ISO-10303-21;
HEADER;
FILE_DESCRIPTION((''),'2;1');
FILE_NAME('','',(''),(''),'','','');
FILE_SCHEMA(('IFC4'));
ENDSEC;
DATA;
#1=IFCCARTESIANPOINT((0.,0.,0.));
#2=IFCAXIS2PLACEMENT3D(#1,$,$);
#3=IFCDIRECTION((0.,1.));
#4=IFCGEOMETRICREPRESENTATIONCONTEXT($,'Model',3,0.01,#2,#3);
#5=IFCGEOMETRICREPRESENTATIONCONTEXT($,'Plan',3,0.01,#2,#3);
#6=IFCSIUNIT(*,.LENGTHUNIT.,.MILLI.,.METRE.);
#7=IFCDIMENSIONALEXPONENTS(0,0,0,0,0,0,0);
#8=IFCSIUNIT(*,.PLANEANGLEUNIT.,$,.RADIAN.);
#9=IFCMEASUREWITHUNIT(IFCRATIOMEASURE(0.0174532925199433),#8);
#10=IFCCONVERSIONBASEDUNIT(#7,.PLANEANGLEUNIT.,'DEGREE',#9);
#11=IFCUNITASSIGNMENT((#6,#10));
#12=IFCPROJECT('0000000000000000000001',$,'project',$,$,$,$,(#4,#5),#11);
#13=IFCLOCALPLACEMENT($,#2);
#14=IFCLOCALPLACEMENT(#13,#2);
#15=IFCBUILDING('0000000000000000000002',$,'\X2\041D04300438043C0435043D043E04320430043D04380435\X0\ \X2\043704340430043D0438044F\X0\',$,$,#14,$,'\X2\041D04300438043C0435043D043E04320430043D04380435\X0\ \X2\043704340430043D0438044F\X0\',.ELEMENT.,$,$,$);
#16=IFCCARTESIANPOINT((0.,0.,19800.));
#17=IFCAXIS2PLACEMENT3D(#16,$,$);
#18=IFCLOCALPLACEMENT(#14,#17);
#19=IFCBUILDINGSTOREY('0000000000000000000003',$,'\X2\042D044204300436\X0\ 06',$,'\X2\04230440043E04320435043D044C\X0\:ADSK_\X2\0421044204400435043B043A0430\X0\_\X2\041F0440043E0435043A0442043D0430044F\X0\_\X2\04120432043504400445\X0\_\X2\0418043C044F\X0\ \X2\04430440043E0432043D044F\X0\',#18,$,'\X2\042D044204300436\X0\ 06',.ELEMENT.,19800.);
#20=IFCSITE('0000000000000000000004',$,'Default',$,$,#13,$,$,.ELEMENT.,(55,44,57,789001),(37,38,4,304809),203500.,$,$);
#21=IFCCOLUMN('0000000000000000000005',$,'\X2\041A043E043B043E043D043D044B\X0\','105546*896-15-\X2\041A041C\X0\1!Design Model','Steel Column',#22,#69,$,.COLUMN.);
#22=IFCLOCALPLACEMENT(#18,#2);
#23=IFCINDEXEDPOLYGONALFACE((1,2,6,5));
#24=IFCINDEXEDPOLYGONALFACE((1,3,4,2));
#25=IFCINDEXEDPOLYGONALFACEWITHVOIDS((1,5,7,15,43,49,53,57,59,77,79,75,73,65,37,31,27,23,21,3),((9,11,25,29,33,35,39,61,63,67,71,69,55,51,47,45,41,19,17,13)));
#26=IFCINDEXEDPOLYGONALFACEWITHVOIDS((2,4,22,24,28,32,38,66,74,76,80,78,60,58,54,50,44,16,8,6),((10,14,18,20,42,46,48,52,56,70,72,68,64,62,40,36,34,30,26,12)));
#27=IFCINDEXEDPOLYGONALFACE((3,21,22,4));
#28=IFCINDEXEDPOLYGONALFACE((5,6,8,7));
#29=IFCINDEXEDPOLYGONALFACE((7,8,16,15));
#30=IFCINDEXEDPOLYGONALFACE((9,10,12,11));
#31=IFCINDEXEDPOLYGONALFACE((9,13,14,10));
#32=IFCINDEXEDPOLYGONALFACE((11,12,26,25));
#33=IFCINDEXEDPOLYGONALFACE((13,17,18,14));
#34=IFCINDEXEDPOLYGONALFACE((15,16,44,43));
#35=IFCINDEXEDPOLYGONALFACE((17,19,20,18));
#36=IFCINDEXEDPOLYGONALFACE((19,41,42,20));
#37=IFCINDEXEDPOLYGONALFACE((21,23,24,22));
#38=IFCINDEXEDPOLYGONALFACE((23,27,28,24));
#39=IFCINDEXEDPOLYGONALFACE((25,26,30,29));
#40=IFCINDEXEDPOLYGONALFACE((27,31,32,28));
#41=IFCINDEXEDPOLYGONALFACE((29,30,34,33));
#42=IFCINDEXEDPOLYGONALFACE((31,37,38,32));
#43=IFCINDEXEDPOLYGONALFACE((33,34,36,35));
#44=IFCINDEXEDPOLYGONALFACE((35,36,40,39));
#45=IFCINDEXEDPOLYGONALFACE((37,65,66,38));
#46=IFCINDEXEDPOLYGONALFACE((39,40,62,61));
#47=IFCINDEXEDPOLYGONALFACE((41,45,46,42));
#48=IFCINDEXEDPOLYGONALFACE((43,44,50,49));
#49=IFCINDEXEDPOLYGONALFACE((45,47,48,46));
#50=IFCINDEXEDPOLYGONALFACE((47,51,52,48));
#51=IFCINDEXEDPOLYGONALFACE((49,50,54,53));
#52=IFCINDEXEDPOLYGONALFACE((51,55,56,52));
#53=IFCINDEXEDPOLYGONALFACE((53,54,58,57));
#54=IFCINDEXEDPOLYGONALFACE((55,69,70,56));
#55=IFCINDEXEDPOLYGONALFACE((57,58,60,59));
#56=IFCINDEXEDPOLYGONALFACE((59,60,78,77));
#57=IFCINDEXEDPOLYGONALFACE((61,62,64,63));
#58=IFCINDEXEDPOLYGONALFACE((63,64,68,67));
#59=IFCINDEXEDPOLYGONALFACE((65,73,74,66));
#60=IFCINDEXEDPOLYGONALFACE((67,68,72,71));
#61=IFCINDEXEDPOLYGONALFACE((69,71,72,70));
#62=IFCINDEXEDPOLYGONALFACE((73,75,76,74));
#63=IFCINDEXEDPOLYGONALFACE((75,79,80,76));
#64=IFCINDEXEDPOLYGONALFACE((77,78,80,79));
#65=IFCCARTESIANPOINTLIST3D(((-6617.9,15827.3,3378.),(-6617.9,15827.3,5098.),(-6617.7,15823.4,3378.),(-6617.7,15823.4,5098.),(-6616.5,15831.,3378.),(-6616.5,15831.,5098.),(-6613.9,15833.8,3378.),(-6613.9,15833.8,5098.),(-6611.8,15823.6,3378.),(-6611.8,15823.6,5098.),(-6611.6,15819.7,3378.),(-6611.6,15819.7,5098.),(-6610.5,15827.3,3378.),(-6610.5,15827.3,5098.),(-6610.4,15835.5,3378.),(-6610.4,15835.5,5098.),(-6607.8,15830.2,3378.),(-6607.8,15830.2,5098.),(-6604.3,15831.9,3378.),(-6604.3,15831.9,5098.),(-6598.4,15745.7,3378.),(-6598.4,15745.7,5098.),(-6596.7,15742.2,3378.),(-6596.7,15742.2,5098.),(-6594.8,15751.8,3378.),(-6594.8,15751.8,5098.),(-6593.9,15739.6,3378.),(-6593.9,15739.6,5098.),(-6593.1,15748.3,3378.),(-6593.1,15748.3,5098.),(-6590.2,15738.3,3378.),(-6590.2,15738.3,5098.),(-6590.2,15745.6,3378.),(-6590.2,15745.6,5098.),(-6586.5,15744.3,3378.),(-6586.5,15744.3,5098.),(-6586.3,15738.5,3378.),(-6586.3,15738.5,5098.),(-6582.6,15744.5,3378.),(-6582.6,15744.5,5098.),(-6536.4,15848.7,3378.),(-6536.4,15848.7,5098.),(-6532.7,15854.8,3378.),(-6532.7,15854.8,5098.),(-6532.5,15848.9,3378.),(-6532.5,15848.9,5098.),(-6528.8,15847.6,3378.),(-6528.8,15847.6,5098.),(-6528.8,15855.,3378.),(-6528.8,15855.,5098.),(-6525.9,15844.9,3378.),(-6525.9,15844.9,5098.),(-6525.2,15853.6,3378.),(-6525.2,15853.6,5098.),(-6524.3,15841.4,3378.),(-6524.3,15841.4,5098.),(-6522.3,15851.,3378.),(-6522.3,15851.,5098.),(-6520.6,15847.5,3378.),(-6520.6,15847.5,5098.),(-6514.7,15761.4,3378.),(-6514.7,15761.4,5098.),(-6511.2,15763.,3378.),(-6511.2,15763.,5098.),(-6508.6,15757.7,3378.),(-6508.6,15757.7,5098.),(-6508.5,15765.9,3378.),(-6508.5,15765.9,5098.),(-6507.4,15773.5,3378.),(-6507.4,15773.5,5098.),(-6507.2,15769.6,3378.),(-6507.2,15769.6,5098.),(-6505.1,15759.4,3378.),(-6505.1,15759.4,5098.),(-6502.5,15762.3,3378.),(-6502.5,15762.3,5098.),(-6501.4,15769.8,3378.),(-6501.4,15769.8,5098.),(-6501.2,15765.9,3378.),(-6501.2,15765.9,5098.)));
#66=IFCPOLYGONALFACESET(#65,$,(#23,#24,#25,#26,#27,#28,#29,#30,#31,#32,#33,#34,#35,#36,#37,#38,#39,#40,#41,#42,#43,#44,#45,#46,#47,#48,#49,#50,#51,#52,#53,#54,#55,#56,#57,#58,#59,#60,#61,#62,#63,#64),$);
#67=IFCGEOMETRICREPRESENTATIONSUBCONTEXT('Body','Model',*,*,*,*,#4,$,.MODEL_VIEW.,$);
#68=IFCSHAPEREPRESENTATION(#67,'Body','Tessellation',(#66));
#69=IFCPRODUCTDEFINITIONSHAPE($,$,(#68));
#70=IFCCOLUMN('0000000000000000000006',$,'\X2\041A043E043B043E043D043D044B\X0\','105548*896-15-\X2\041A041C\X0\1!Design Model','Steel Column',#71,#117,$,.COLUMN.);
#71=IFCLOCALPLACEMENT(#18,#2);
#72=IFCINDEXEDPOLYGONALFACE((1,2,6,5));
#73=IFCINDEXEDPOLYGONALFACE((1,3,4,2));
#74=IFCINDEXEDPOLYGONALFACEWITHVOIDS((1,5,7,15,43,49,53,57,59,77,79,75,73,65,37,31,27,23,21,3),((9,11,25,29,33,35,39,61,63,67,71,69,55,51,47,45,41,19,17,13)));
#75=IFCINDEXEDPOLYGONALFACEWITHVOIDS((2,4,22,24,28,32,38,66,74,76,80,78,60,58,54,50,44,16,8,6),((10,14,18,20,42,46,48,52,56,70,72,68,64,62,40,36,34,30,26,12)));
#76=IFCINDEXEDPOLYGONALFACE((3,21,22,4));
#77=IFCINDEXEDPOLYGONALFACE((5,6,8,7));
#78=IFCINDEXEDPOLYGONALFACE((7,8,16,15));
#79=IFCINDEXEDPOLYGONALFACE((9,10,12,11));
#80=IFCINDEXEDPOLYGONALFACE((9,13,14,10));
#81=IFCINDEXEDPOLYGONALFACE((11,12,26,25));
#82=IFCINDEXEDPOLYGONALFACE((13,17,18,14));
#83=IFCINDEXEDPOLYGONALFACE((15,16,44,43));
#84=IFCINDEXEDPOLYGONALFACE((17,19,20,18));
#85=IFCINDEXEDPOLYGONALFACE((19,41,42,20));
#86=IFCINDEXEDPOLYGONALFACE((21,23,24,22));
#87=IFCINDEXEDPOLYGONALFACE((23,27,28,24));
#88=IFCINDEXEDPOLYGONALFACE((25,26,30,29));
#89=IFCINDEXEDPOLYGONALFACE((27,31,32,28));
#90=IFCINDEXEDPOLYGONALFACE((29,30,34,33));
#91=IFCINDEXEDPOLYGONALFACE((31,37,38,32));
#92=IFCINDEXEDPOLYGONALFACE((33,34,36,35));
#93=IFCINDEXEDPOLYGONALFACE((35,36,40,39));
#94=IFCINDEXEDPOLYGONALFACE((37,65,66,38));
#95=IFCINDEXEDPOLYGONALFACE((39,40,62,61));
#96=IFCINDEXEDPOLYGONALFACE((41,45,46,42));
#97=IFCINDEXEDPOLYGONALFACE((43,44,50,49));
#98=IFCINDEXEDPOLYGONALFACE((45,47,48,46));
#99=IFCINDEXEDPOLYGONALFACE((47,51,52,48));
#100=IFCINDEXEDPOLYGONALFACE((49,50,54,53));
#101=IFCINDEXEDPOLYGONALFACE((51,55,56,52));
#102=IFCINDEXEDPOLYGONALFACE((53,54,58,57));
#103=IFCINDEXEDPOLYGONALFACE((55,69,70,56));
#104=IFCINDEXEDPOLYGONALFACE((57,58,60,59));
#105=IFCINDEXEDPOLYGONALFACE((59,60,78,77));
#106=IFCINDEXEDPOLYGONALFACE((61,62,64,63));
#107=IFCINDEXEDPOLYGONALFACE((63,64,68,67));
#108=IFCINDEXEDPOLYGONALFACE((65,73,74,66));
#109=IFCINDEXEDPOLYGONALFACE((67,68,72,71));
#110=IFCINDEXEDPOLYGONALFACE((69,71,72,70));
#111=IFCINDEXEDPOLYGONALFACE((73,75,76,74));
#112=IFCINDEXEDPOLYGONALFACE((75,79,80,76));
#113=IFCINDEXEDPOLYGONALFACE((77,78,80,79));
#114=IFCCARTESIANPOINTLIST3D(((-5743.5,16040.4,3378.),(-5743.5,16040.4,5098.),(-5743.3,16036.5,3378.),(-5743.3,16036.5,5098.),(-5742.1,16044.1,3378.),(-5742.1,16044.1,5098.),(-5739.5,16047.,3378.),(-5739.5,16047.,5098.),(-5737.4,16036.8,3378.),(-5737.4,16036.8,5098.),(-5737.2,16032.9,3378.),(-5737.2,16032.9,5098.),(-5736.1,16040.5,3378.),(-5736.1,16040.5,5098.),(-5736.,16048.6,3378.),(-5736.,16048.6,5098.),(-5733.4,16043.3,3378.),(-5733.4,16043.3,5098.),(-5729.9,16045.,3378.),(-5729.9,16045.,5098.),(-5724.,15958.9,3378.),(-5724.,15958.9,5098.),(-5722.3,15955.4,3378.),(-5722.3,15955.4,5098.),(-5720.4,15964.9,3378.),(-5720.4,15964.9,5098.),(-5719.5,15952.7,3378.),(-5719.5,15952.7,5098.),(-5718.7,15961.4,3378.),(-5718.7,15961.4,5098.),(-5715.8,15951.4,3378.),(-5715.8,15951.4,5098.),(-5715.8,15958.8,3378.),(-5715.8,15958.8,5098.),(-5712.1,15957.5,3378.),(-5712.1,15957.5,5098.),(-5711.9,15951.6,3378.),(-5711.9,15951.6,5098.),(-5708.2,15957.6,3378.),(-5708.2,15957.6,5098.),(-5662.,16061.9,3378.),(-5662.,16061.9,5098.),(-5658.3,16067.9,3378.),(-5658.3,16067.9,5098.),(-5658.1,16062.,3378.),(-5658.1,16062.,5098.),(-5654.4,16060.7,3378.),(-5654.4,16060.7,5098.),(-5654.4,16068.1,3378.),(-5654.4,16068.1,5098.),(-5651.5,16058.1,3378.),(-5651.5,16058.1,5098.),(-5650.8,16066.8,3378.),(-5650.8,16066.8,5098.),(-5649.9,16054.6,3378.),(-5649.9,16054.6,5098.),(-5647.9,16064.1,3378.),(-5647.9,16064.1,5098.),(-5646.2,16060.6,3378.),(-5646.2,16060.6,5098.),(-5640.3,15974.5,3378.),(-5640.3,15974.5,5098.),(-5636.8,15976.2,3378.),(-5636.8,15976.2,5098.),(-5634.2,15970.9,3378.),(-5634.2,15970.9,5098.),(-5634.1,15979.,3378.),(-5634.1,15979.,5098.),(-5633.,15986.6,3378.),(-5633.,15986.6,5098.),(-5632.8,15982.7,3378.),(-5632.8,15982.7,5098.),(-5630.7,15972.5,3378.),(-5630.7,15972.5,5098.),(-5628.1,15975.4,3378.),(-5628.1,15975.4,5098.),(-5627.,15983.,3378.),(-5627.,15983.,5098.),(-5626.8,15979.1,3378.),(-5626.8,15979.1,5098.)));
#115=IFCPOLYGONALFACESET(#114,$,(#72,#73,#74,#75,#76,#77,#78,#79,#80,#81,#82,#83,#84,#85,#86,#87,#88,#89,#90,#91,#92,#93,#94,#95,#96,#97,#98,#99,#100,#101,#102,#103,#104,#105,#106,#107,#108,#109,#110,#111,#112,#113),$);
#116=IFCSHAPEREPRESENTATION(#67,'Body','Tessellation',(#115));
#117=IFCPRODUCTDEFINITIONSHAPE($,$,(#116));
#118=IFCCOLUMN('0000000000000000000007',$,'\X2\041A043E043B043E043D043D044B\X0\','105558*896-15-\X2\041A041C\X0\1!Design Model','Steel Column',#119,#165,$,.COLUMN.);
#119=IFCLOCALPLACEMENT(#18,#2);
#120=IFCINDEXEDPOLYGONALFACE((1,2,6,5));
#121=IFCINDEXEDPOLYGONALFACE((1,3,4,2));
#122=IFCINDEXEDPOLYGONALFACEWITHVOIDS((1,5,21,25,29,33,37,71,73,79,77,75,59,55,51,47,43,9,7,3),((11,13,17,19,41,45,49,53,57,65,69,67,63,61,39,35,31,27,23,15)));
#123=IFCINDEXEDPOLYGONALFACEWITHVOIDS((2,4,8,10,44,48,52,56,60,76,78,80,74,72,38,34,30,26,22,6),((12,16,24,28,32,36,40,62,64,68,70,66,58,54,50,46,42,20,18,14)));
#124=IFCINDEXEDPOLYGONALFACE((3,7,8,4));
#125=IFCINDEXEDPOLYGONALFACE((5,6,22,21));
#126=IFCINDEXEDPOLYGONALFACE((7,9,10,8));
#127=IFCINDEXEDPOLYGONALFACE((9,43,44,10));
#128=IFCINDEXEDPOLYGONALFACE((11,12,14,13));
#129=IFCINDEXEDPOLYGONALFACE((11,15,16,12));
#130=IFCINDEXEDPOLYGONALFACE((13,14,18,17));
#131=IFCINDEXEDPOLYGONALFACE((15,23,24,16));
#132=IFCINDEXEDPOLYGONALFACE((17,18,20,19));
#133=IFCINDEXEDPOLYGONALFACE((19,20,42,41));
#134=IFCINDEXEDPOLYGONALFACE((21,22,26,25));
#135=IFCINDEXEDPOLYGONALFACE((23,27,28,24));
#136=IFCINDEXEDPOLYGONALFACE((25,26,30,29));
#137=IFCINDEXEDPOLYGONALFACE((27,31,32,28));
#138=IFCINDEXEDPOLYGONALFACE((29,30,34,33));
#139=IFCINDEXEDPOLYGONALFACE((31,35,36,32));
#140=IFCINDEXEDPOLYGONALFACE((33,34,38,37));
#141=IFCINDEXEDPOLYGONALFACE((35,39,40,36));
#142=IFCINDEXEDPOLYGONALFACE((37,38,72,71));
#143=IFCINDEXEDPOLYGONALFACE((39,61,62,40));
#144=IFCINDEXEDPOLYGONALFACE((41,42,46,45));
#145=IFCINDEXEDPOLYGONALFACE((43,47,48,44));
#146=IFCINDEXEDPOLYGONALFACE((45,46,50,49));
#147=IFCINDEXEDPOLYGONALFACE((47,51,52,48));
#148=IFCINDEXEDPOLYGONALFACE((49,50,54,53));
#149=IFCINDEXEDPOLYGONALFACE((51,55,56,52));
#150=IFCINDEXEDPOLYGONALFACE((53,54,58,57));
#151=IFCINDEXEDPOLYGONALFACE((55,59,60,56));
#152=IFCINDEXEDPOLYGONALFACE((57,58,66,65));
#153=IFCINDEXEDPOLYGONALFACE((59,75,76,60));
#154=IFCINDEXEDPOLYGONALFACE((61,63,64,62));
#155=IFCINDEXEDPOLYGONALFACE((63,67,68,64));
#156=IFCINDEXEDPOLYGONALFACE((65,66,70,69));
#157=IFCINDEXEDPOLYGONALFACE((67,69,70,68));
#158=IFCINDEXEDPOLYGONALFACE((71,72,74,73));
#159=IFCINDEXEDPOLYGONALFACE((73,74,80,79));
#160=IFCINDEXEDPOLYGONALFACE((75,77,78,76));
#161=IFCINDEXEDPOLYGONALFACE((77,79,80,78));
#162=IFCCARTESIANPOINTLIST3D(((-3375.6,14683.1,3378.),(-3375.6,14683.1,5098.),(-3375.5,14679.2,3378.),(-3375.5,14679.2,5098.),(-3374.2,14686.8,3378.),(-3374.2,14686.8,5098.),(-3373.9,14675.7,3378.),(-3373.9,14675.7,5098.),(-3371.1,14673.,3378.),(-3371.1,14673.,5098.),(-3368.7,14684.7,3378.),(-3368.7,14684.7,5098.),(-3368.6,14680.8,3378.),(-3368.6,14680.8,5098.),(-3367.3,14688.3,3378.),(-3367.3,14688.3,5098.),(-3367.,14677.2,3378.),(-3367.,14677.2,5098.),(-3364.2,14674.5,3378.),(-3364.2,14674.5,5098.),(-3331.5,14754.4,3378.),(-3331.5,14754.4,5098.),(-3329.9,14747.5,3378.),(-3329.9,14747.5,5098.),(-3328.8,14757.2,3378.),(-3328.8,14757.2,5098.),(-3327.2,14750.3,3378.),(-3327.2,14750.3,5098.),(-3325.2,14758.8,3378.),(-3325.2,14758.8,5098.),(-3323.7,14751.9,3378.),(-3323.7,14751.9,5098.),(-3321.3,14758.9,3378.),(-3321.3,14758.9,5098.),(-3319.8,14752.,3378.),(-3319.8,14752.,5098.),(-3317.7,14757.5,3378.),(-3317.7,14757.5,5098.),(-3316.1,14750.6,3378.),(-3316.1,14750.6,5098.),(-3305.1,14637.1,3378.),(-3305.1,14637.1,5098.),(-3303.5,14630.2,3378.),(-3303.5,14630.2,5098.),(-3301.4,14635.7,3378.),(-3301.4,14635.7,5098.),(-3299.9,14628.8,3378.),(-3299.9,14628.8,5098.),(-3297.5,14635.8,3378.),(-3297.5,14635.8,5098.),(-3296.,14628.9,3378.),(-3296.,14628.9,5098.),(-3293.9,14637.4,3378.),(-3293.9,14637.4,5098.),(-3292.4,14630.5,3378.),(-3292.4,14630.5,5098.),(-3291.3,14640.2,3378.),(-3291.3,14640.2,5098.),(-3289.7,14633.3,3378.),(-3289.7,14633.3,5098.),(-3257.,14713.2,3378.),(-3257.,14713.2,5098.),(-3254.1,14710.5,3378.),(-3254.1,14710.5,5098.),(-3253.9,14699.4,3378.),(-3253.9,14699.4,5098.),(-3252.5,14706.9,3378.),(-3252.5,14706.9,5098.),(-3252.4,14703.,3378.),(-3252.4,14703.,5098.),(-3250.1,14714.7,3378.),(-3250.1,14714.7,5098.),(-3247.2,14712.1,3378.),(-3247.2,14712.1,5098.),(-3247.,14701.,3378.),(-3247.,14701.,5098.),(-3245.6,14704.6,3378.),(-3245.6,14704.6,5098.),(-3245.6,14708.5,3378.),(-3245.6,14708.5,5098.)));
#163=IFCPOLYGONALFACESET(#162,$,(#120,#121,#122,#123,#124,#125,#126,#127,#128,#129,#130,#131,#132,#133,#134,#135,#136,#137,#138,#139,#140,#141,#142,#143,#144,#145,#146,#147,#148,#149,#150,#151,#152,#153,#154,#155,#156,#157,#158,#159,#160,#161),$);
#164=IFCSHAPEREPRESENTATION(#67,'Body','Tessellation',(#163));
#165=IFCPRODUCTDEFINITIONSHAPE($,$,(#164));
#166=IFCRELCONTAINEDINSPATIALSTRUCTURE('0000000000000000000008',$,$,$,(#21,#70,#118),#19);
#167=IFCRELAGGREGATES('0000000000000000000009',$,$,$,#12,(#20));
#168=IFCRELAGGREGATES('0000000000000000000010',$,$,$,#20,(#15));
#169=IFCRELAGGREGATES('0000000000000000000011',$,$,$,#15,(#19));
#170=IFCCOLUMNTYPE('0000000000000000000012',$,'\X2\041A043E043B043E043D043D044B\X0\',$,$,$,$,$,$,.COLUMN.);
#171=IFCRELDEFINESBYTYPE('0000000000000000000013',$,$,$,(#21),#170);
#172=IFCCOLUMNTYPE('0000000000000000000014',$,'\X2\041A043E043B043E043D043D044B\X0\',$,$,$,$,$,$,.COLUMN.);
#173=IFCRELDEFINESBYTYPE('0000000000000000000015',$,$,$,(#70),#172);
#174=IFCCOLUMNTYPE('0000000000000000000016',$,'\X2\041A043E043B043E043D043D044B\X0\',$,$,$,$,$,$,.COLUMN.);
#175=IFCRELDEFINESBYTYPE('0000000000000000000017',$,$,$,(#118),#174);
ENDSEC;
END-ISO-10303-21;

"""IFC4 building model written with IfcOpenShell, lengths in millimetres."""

from ifc_helpers import new_model, entity, si_unit, converted_unit, direction, frame, origin, place, context, subcontext, project, spatial, indexed_curve, outline, extrude, type_object, element, save


model = new_model("IFC4")

# Units and contexts
model_context = context("Model", 3, precision=0.01, world=origin(), true_north=direction((0.0, 1.0)))
plan_context = context("Plan", 3, precision=0.01, world=origin(), true_north=direction((0.0, 1.0)))
body_context = subcontext(model_context, "Body", "Model", "MODEL_VIEW")
ifc_project = project(units=[si_unit("LENGTHUNIT", "METRE", prefix="MILLI"), converted_unit("PLANEANGLEUNIT", "DEGREE", entity("IfcRatioMeasure", 0.0174532925199433), si_unit("PLANEANGLEUNIT", "RADIAN"), dimensions=[0, 0, 0, 0, 0, 0, 0])], contexts=[model_context, plan_context])

# Site, building, storey
site_placement = place(None, origin())
site = spatial("IfcSite", under=ifc_project, at=site_placement, Name="Default", CompositionType="ELEMENT", RefLatitude=(55, 44, 57, 789001), RefLongitude=(37, 38, 4, 304809), RefElevation=203500.0)
building_placement = place(site_placement, origin())
building = spatial("IfcBuilding", under=site, at=building_placement, Name="Наименование здания", LongName="Наименование здания", CompositionType="ELEMENT")
storey_placement = place(building_placement, frame((0.0, 0.0, 19800.0)))
storey = spatial("IfcBuildingStorey", under=building, at=storey_placement, Name="Этаж 06", ObjectType="Уровень:ADSK_Стрелка_Проектная_Вверх_Имя уровня", LongName="Этаж 06", CompositionType="ELEMENT", Elevation=19800.0)

# Columns
column_type_1 = type_object("IfcColumnType", Name="Колонны", PredefinedType="COLUMN")
placement_1 = place(storey_placement, origin())
element("IfcColumn", 1, at=placement_1, inside=storey, type_object=column_type_1, Name="Колонны", Description="105546*896-15-КМ1!Design Model", ObjectType="Steel Column", PredefinedType="COLUMN", context=body_context, shape_type="SweptSolid", body=[
    extrude(outline(indexed_curve([(29.5, -56.8), (33.4, -56.8), (37.0, -55.3), (39.7, -52.6), (41.2, -49.0), (56.8, 29.5), (56.8, 33.4), (55.3, 37.0), (52.6, 39.7), (49.0, 41.2), (-29.5, 56.8), (-33.4, 56.8), (-37.0, 55.3), (-39.7, 52.6), (-41.2, 49.0), (-56.8, -29.5), (-56.8, -33.4), (-55.3, -37.0), (-52.6, -39.7), (-49.0, -41.2), (29.5, -56.8)], self_intersect=False), holes=[indexed_curve([(-43.1, -37.3), (-46.7, -35.8), (-49.5, -33.1), (-51.0, -29.5), (-51.0, -25.5), (-37.3, 43.1), (-35.8, 46.7), (-33.1, 49.5), (-29.5, 51.0), (-25.5, 51.0), (43.1, 37.3), (46.7, 35.8), (49.5, 33.1), (51.0, 29.5), (51.0, 25.5), (37.3, -43.1), (35.8, -46.7), (33.1, -49.5), (29.5, -51.0), (25.5, -51.0), (-43.1, -37.3)], self_intersect=False)]), frame((-6559.5, 15796.6, 3378.0), z_axis=(0.0, 0.0, 1.0), x_axis=(-0.904974, -0.425466, 0.0)), (0.0, 0.0, 1.0), 1720.0),
])
column_type_2 = type_object("IfcColumnType", Name="Колонны", PredefinedType="COLUMN")
element("IfcColumn", 2, at=placement_1, inside=storey, type_object=column_type_2, Name="Колонны", Description="105548*896-15-КМ1!Design Model", ObjectType="Steel Column", PredefinedType="COLUMN", context=body_context, shape_type="SweptSolid", body=[
    extrude(outline(indexed_curve([(29.5, -56.8), (33.4, -56.8), (37.0, -55.3), (39.7, -52.6), (41.2, -49.0), (56.8, 29.5), (56.8, 33.4), (55.3, 37.0), (52.6, 39.7), (49.0, 41.2), (-29.5, 56.8), (-33.4, 56.8), (-37.0, 55.3), (-39.7, 52.6), (-41.2, 49.0), (-56.8, -29.5), (-56.8, -33.4), (-55.3, -37.0), (-52.6, -39.7), (-49.0, -41.2), (29.5, -56.8)], self_intersect=False), holes=[indexed_curve([(-43.1, -37.3), (-46.7, -35.8), (-49.5, -33.1), (-51.0, -29.5), (-51.0, -25.5), (-37.3, 43.1), (-35.8, 46.7), (-33.1, 49.5), (-29.5, 51.0), (-25.5, 51.0), (43.1, 37.3), (46.7, 35.8), (49.5, 33.1), (51.0, 29.5), (51.0, 25.5), (37.3, -43.1), (35.8, -46.7), (33.1, -49.5), (29.5, -51.0), (25.5, -51.0), (-43.1, -37.3)], self_intersect=False)]), frame((-5685.1, 16009.8, 3378.0), z_axis=(0.0, 0.0, 1.0), x_axis=(-0.904974, -0.425466, 0.0)), (0.0, 0.0, 1.0), 1720.0),
])
column_type_3 = type_object("IfcColumnType", Name="Колонны", PredefinedType="COLUMN")
element("IfcColumn", 3, at=placement_1, inside=storey, type_object=column_type_3, Name="Колонны", Description="105558*896-15-КМ1!Design Model", ObjectType="Steel Column", PredefinedType="COLUMN", context=body_context, shape_type="SweptSolid", body=[
    extrude(outline(indexed_curve([(29.5, -56.8), (33.4, -56.8), (37.0, -55.3), (39.7, -52.6), (41.2, -49.0), (56.8, 29.5), (56.8, 33.4), (55.3, 37.0), (52.6, 39.7), (49.0, 41.2), (-29.5, 56.8), (-33.4, 56.8), (-37.0, 55.3), (-39.7, 52.6), (-41.2, 49.0), (-56.8, -29.5), (-56.8, -33.4), (-55.3, -37.0), (-52.6, -39.7), (-49.0, -41.2), (29.5, -56.8)], self_intersect=False), holes=[indexed_curve([(-43.1, -37.3), (-46.7, -35.8), (-49.5, -33.1), (-51.0, -29.5), (-51.0, -25.5), (-37.3, 43.1), (-35.8, 46.7), (-33.1, 49.5), (-29.5, 51.0), (-25.5, 51.0), (43.1, 37.3), (46.7, 35.8), (49.5, 33.1), (51.0, 29.5), (51.0, 25.5), (37.3, -43.1), (35.8, -46.7), (33.1, -49.5), (29.5, -51.0), (25.5, -51.0), (-43.1, -37.3)], self_intersect=False)]), frame((-3310.6, 14693.9, 3378.0), z_axis=(0.0, 0.0, 1.0), x_axis=(-0.933263, 0.359194, 0.0)), (0.0, 0.0, 1.0), 1720.0),
])

save(model, "model.ifc")
